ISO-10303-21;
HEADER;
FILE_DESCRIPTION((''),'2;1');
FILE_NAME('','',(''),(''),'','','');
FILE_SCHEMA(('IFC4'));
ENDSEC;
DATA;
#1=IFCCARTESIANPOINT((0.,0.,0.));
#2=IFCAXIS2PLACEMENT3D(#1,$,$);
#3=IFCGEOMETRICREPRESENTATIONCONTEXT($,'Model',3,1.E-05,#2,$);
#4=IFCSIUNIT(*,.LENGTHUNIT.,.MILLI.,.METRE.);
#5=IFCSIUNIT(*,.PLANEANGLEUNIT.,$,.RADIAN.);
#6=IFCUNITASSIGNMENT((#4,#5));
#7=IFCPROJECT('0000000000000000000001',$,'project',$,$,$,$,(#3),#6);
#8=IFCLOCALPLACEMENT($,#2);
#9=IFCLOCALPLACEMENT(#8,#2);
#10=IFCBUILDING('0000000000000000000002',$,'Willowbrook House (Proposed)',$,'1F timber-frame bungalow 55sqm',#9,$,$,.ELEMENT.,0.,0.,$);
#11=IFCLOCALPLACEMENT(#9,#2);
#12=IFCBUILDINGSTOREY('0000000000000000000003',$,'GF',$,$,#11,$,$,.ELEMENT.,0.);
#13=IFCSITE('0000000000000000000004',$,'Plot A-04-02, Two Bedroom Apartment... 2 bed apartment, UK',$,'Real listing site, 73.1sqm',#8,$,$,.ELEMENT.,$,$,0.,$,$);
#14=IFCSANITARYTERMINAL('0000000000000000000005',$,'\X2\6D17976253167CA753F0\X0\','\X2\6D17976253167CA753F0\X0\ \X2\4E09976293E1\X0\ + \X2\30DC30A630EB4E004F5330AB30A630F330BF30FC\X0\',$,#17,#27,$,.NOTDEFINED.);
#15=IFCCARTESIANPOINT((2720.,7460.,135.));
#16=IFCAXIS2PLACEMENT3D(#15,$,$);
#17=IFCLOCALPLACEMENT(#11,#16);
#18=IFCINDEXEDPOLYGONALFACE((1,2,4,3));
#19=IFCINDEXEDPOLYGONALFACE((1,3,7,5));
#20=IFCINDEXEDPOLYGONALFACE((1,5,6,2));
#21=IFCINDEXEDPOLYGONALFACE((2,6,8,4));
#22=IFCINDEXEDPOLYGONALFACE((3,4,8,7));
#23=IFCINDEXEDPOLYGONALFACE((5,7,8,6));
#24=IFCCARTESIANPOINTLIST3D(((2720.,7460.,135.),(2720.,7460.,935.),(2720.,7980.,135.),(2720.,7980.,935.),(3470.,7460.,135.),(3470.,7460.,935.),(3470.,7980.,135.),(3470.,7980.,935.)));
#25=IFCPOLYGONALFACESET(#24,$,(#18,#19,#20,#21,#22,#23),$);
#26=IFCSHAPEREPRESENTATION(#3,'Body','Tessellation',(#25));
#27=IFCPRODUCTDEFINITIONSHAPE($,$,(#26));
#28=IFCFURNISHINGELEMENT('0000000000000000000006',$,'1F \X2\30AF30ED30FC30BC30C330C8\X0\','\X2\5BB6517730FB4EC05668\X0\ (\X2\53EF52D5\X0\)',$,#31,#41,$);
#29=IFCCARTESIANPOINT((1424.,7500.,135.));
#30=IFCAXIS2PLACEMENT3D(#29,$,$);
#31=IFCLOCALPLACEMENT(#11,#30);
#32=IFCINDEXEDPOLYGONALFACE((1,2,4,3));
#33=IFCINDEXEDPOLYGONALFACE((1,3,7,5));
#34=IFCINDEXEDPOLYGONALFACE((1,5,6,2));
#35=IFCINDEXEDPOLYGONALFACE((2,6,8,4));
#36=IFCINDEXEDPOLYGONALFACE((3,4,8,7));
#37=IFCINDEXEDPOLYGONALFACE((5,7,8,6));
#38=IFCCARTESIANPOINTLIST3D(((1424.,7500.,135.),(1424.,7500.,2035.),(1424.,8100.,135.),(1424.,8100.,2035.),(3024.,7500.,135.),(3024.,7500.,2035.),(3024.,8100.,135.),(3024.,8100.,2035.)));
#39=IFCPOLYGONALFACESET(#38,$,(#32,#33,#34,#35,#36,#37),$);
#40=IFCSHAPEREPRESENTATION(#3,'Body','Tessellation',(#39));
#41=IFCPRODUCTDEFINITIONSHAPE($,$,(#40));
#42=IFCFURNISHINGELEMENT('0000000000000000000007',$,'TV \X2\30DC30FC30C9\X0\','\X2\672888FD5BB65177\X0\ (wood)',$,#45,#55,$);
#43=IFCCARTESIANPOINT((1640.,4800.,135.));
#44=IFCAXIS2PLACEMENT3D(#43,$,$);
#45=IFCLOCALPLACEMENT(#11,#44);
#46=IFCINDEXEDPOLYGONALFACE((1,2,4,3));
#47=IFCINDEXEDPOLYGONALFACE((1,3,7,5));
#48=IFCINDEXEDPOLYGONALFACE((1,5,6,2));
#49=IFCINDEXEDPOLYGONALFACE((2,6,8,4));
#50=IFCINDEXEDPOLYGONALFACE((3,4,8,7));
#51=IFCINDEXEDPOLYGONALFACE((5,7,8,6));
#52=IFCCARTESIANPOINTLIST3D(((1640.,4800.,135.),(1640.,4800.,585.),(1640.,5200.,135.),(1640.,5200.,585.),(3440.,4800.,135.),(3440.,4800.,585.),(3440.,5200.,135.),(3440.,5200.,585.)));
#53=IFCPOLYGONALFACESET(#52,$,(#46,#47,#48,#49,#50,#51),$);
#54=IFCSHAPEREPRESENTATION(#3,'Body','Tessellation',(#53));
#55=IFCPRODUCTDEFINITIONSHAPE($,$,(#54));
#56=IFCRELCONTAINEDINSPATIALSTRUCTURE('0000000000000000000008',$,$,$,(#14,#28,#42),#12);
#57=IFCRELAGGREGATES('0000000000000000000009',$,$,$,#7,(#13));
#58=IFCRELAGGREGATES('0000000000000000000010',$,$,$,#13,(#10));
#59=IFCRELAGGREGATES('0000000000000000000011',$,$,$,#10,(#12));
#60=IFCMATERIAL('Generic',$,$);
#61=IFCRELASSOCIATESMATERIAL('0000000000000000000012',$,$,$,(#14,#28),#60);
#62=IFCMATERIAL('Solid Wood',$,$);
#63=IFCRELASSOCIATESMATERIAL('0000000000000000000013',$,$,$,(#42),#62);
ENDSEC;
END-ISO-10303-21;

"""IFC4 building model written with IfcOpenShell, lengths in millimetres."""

from ifc_helpers import new_model, si_unit, frame, frame_2d, origin, place, context, project, spatial, rectangle, extrude, material, element, save


model = new_model("IFC4")

# Units and contexts
model_context = context("Model", 3, precision=1e-05, world=origin())
ifc_project = project(units=[si_unit("LENGTHUNIT", "METRE", prefix="MILLI"), si_unit("PLANEANGLEUNIT", "RADIAN")], contexts=[model_context])

# Site, building, storey
site_placement = place(None, origin())
site = spatial("IfcSite", under=ifc_project, at=site_placement, Name="Plot A-04-02, Two Bedroom Apartment... 2 bed apartment, UK", ObjectType="Real listing site, 73.1sqm", CompositionType="ELEMENT", RefElevation=0.0)
building_placement = place(site_placement, origin())
building = spatial("IfcBuilding", under=site, at=building_placement, Name="Willowbrook House (Proposed)", ObjectType="1F timber-frame bungalow 55sqm", CompositionType="ELEMENT", ElevationOfRefHeight=0.0, ElevationOfTerrain=0.0)
storey_placement = place(building_placement, origin())
storey = spatial("IfcBuildingStorey", under=building, at=storey_placement, Name="GF", CompositionType="ELEMENT", Elevation=0.0)

# Shared definitions
ifc_material_1 = material(Name="Solid Wood")

# Shared definitions
ifc_material_2 = material(Name="Generic")

# Sanitary terminal
sanitary_terminal_1_placement = place(storey_placement, frame((2720.0, 7460.0, 135.0)))
element("IfcSanitaryTerminal", 1, at=sanitary_terminal_1_placement, inside=storey, material=ifc_material_2, Name="洗面化粧台", Description="洗面化粧台 三面鏡 + ボウル一体カウンター", PredefinedType="NOTDEFINED", context=model_context, shape_type="SweptSolid", body=[
    extrude(rectangle(XDim=750.0, YDim=520.0, at=frame_2d((375.0, 260.0))), frame((2720.0, 7460.0, 135.0)), (0.0, 0.0, 1.0), 800.0),
])

# Furnishing elements
furnishing_1_placement = place(storey_placement, frame((1424.0, 7500.0, 135.0)))
element("IfcFurnishingElement", 2, at=furnishing_1_placement, inside=storey, material=ifc_material_2, Name="1F クローゼット", Description="家具・什器 (可動)", context=model_context, shape_type="SweptSolid", body=[
    extrude(rectangle(XDim=1600.0, YDim=600.0, at=frame_2d((800.0, 300.0))), frame((1424.0, 7500.0, 135.0)), (0.0, 0.0, 1.0), 1900.0),
])
furnishing_2_placement = place(storey_placement, frame((1640.0, 4800.0, 135.0)))
element("IfcFurnishingElement", 3, at=furnishing_2_placement, inside=storey, material=ifc_material_1, Name="TV ボード", Description="木製家具 (wood)", context=model_context, shape_type="SweptSolid", body=[
    extrude(rectangle(XDim=1800.0, YDim=400.0, at=frame_2d((900.0, 200.0))), frame((1640.0, 4800.0, 135.0)), (0.0, 0.0, 1.0), 450.0),
])

save(model, "model.ifc")
